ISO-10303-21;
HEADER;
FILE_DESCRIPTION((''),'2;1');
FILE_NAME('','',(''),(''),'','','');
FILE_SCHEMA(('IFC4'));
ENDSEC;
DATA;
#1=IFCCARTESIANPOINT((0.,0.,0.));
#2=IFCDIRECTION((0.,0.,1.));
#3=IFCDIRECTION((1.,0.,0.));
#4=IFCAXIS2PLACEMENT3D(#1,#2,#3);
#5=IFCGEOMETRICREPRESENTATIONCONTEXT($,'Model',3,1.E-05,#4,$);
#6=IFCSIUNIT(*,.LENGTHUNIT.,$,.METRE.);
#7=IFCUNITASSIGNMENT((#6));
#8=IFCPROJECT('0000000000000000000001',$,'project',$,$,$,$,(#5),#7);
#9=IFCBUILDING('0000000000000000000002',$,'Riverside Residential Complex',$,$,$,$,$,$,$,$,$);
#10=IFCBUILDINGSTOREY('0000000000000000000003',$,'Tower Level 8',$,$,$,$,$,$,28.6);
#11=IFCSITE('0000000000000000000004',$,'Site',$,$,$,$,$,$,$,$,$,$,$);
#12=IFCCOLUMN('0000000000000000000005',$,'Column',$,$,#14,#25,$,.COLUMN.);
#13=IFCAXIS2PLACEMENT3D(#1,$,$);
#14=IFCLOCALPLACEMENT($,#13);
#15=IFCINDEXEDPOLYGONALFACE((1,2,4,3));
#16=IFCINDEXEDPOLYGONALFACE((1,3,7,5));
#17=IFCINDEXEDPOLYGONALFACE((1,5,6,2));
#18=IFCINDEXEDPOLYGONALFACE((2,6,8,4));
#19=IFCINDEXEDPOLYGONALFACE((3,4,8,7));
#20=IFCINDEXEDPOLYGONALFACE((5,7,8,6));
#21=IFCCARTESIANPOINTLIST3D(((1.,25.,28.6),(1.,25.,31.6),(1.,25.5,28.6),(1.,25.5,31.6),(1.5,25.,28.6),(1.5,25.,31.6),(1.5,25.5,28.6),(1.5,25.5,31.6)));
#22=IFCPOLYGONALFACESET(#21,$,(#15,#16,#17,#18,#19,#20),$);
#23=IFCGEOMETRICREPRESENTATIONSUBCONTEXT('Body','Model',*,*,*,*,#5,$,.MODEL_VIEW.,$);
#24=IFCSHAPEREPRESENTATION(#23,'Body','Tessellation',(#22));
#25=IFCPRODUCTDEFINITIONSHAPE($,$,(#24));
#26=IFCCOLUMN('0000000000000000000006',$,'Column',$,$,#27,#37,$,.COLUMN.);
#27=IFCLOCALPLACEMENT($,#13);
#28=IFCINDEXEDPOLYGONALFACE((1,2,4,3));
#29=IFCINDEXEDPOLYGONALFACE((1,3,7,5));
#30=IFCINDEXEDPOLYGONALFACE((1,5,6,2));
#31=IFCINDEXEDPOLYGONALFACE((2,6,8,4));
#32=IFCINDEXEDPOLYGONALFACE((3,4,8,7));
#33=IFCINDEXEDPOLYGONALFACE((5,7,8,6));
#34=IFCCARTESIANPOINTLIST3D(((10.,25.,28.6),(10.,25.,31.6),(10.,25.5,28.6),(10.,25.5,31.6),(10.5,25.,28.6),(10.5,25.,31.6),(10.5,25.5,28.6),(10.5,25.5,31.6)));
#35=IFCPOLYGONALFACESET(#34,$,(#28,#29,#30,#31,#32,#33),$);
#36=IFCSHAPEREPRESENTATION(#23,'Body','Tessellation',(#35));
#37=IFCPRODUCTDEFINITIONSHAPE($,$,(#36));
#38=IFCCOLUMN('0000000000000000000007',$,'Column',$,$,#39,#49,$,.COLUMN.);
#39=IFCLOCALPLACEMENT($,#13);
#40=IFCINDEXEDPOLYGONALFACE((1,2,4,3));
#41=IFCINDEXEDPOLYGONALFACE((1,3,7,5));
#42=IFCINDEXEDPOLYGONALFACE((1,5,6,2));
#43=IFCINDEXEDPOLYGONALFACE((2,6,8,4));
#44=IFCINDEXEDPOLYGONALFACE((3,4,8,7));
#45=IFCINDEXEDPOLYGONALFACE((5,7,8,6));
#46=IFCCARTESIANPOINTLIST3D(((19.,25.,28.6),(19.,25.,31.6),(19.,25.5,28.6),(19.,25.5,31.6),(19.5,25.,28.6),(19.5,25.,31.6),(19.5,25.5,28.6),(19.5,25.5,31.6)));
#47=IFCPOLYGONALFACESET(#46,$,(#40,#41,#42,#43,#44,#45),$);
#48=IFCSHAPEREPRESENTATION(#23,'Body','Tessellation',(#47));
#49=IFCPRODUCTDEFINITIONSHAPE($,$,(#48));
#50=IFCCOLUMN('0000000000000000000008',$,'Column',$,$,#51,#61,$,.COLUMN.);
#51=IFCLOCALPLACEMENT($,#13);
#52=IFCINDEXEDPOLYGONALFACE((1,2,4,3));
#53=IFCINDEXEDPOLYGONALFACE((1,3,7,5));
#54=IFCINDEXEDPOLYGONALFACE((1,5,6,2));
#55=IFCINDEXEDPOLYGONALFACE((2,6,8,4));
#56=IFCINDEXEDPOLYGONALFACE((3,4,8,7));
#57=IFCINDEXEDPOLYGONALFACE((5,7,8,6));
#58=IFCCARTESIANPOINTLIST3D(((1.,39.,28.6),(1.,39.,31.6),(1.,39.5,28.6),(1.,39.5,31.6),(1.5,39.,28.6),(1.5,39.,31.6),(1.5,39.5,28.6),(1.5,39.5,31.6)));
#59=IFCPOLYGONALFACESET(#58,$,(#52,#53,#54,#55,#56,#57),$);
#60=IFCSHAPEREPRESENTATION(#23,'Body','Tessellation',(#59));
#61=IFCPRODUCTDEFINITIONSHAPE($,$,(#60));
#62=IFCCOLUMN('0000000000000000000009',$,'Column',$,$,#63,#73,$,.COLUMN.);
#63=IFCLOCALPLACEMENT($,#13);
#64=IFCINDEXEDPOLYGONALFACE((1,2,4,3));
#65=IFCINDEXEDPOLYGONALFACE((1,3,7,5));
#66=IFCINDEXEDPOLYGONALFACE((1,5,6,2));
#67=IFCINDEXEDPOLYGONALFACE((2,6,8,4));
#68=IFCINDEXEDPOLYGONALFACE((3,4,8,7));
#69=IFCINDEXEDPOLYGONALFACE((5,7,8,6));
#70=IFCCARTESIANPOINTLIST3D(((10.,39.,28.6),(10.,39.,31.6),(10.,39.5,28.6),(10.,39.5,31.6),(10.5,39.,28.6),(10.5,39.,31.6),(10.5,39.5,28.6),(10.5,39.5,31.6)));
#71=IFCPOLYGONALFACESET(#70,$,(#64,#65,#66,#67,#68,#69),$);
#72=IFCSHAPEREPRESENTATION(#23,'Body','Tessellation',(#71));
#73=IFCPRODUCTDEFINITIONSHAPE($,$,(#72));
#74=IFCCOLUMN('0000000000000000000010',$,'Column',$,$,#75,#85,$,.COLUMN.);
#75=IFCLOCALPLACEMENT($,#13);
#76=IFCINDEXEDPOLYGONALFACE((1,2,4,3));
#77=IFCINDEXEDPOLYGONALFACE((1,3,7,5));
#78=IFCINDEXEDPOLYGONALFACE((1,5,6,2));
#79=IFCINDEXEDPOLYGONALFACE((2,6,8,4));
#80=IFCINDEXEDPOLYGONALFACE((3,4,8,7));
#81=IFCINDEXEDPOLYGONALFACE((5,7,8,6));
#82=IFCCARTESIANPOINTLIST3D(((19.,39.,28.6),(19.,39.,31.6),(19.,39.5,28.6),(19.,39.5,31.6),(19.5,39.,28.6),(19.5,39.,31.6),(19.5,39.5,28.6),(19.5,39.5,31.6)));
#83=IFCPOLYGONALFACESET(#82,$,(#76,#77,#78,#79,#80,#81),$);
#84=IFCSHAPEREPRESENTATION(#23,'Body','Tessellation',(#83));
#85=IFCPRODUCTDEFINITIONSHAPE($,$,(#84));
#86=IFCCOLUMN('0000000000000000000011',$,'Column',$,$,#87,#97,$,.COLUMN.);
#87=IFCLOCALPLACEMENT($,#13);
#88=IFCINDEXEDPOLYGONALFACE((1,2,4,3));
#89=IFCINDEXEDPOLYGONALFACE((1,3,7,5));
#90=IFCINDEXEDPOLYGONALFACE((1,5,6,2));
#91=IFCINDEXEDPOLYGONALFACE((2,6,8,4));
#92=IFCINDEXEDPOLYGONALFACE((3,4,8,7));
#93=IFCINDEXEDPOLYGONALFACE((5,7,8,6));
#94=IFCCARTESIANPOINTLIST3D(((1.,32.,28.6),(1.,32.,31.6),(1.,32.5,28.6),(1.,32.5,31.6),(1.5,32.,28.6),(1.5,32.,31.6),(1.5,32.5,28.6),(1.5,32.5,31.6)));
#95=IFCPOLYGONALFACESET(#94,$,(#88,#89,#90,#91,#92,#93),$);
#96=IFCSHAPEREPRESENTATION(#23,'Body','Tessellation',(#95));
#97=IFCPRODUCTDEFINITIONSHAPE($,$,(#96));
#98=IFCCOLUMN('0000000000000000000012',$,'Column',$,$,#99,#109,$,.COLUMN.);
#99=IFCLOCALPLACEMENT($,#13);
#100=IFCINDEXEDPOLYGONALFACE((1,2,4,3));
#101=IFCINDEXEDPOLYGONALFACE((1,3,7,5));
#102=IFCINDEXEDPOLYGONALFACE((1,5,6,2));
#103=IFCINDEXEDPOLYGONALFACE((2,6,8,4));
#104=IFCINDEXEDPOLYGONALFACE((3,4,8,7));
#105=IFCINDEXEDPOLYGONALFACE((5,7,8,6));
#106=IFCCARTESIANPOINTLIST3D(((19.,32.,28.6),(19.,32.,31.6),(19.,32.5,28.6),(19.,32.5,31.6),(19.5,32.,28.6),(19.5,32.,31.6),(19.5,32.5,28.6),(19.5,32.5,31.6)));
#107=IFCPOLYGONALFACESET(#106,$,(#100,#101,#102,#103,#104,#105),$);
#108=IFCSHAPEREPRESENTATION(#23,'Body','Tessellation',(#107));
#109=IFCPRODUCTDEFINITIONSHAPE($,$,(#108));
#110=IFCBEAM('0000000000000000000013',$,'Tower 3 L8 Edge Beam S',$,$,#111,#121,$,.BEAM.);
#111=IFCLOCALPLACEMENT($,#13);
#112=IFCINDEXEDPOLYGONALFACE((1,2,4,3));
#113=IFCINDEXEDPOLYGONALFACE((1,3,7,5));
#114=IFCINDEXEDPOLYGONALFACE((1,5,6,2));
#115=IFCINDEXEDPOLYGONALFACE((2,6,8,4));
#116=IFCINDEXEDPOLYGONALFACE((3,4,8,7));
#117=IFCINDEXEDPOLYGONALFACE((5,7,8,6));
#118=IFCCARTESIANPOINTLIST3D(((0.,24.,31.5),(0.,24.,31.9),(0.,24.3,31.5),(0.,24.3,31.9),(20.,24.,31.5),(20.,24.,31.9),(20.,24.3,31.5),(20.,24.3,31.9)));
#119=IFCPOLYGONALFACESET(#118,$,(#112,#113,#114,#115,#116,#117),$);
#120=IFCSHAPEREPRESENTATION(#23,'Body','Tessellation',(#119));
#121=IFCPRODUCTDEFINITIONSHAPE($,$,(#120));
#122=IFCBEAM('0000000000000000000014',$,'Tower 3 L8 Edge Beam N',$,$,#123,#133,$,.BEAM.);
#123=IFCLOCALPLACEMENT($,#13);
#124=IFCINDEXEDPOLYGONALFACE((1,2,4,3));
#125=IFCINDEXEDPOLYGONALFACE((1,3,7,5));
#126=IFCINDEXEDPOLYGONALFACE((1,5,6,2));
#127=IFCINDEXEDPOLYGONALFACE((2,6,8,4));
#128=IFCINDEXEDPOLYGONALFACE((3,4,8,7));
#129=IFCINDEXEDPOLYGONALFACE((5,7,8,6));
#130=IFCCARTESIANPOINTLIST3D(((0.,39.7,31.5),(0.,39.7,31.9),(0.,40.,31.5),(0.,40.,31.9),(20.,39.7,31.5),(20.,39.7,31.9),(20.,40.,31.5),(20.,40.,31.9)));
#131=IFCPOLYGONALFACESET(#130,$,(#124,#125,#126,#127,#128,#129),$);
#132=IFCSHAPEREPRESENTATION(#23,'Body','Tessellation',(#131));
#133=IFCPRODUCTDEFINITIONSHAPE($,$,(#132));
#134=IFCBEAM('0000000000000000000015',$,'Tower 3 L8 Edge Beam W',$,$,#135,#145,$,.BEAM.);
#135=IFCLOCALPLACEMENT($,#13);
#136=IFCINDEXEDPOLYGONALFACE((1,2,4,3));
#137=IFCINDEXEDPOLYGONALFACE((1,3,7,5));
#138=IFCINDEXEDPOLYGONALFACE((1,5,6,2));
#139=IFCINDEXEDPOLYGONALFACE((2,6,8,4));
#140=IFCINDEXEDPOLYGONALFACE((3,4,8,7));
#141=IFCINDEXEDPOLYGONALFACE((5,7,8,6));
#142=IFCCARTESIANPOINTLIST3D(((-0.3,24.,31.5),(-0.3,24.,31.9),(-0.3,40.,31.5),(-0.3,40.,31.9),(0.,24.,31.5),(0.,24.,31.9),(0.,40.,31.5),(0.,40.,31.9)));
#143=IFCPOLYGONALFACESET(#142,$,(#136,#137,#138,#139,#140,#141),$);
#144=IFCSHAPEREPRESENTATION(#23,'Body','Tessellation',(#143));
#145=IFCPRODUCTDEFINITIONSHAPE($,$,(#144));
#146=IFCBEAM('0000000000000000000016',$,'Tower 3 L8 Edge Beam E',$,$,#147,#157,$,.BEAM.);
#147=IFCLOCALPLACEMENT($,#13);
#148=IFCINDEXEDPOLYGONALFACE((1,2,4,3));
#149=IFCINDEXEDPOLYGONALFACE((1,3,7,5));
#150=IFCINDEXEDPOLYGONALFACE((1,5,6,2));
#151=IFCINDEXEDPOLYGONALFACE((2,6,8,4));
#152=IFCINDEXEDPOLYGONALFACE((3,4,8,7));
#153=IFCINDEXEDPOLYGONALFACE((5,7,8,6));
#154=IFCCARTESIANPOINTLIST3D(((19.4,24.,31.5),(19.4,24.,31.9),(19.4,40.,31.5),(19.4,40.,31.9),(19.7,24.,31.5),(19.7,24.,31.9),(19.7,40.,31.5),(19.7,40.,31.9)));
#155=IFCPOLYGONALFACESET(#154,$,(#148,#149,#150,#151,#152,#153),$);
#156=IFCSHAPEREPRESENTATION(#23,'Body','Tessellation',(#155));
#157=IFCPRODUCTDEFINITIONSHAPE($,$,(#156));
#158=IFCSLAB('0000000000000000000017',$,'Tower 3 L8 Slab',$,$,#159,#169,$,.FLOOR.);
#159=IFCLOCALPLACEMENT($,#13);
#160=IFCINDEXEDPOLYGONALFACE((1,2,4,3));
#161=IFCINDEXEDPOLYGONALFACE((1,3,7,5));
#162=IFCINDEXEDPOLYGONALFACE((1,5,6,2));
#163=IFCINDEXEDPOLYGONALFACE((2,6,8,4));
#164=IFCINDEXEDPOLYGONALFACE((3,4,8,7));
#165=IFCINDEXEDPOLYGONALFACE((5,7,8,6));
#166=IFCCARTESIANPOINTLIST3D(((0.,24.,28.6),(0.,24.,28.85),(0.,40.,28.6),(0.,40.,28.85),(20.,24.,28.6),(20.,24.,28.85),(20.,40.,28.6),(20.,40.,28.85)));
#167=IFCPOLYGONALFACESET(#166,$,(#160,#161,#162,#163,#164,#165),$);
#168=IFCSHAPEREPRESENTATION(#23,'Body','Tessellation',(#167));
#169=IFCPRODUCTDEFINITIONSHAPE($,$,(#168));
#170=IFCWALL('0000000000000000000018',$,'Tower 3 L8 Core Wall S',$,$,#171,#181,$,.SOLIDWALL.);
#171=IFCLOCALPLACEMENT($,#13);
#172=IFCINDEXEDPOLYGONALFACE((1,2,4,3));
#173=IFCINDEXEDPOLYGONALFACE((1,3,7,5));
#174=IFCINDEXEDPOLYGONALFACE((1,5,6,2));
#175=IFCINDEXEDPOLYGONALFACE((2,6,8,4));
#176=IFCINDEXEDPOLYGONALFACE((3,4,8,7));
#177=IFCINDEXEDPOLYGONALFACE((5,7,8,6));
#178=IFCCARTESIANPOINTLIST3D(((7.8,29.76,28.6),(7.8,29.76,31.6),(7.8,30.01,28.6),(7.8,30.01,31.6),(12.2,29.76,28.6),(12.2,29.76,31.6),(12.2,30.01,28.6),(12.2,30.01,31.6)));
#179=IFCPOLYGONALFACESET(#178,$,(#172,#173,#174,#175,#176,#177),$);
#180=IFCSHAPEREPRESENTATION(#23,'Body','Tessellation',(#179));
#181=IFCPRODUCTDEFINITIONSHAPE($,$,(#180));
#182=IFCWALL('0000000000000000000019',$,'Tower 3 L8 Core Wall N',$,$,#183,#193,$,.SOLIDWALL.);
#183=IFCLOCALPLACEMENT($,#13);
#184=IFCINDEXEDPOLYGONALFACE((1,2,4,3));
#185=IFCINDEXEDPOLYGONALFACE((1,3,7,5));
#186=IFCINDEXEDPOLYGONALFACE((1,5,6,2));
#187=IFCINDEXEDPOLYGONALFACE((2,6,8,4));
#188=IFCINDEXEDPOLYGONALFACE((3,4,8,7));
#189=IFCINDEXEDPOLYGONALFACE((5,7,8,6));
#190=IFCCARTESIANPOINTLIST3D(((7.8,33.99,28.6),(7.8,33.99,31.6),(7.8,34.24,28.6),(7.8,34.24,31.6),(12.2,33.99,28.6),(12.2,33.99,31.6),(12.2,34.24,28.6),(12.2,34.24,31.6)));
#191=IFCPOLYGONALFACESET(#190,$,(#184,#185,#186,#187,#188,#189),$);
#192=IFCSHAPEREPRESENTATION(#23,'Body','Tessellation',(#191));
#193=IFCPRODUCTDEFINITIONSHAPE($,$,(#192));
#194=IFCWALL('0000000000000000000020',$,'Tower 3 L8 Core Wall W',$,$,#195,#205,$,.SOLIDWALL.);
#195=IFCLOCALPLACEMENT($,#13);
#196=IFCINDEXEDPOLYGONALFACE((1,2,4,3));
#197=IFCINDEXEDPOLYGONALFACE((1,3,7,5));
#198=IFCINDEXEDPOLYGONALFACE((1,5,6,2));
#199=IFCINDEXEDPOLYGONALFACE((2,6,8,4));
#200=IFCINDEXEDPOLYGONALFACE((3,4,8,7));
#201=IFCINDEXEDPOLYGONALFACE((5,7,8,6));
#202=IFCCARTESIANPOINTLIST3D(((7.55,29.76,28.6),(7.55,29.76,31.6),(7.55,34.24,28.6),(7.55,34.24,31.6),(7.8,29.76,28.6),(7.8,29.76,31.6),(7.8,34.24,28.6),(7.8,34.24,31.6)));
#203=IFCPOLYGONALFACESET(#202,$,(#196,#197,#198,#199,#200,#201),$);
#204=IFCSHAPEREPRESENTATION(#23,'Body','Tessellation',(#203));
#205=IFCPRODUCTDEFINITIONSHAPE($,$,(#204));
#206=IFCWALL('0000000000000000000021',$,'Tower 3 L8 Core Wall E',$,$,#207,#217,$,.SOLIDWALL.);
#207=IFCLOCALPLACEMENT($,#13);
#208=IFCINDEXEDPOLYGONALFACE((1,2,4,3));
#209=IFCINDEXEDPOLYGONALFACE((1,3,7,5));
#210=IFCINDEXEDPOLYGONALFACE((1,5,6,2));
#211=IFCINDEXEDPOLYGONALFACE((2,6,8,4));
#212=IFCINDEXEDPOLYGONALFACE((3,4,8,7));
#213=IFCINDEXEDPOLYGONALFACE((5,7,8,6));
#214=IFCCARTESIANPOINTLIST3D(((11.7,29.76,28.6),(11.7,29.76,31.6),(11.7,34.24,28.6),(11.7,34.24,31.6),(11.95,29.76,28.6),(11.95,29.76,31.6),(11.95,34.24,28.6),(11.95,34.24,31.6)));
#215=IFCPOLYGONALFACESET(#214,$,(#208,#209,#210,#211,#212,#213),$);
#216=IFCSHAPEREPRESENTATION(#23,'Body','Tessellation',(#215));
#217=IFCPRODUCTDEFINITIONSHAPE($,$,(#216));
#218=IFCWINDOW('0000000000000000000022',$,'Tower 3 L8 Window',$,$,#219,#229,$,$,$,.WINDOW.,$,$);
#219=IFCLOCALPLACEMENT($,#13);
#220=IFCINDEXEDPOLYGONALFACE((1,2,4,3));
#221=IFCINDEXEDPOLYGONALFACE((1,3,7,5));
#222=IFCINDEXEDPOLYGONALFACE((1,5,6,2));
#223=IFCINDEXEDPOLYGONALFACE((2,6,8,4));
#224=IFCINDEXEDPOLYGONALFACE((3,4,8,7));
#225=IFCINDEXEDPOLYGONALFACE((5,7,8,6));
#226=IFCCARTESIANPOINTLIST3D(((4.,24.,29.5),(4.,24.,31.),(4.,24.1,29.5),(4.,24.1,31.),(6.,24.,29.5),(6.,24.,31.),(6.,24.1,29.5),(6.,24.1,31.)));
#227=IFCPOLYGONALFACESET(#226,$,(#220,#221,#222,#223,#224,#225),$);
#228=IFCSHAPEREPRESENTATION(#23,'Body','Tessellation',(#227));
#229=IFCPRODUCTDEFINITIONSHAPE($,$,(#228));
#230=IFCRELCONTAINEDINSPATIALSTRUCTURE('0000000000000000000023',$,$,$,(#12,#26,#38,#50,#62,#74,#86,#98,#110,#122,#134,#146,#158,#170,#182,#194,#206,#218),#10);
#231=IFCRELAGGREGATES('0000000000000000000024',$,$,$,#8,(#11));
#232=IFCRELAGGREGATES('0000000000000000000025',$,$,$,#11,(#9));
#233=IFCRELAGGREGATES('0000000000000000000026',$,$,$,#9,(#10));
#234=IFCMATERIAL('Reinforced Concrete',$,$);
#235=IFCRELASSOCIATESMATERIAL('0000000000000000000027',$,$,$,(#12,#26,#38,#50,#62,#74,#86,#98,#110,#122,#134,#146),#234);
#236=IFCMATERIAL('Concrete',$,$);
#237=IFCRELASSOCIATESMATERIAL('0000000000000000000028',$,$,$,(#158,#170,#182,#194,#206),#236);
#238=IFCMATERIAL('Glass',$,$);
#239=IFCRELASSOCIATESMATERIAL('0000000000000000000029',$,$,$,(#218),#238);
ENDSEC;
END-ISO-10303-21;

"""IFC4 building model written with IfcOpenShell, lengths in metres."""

from ifc_helpers import new_model, si_unit, frame, origin_with_axes, place, context, subcontext, project, spatial, line, indexed_curve, outline, extrude, material, element, save


model = new_model("IFC4")

# Units and contexts
model_context = context("Model", 3, precision=1e-05, world=origin_with_axes())
body_context = subcontext(model_context, "Body", "Model", "MODEL_VIEW")
ifc_project = project(units=[si_unit("LENGTHUNIT", "METRE")], contexts=[model_context])

# Site, building, storey
site = spatial("IfcSite", under=ifc_project, Name="Site")
building = spatial("IfcBuilding", under=site, Name="Riverside Residential Complex")
storey = spatial("IfcBuildingStorey", under=building, Name="Tower Level 8", Elevation=28.6)

# Columns
ifc_material_1 = material(Name="Reinforced Concrete")
for number, where, z_axis, x_axis, name in (
    (1, (1.0, 25.0, 28.6), (0.0, 0.0, 1.0), (1.0, 0.0, 0.0), "Column"),
    (2, (10.0, 25.0, 28.6), (0.0, 0.0, 1.0), (1.0, 0.0, 0.0), "Column"),
    (3, (19.0, 25.0, 28.6), (0.0, 0.0, 1.0), (1.0, 0.0, 0.0), "Column"),
    (4, (1.0, 39.0, 28.6), (0.0, 0.0, 1.0), (1.0, 0.0, 0.0), "Column"),
    (5, (10.0, 39.0, 28.6), (0.0, 0.0, 1.0), (1.0, 0.0, 0.0), "Column"),
    (6, (19.0, 39.0, 28.6), (0.0, 0.0, 1.0), (1.0, 0.0, 0.0), "Column"),
    (7, (1.0, 32.0, 28.6), (0.0, 0.0, 1.0), (1.0, 0.0, 0.0), "Column"),
    (8, (19.0, 32.0, 28.6), (0.0, 0.0, 1.0), (1.0, 0.0, 0.0), "Column"),
):
    element("IfcColumn", number, at=place(None, frame(where, z_axis=z_axis, x_axis=x_axis)), inside=storey, material=ifc_material_1, Name=name, PredefinedType="COLUMN", context=body_context, shape_type="SweptSolid", body=[
        extrude(outline(indexed_curve([(0.0, 0.0), (0.5, 0.0), (0.5, 0.5), (0.0, 0.5)], segments=[line(1, 2, 3, 4, 1)])), origin_with_axes(), (0.0, 0.0, 1.0), 3.0),
    ])

# Beams
for number, where, z_axis, x_axis, name in (
    (9, (0.0, 24.0, 31.5), (0.0, 0.0, 1.0), (1.0, 0.0, 0.0), "Tower 3 L8 Edge Beam S"),
    (10, (0.0, 39.7, 31.5), (0.0, 0.0, 1.0), (1.0, 0.0, 0.0), "Tower 3 L8 Edge Beam N"),
):
    element("IfcBeam", number, at=place(None, frame(where, z_axis=z_axis, x_axis=x_axis)), inside=storey, material=ifc_material_1, Name=name, PredefinedType="BEAM", context=body_context, shape_type="SweptSolid", body=[
        extrude(outline(indexed_curve([(0.0, 0.0), (20.0, 0.0), (20.0, 0.3), (0.0, 0.3)], segments=[line(1, 2, 3, 4, 1)])), origin_with_axes(), (0.0, 0.0, 1.0), 0.4),
    ])
for number, where, z_axis, x_axis, name in (
    (11, (0.0, 24.0, 31.5), (0.0, 0.0, 1.0), (0.0, 1.0, 0.0), "Tower 3 L8 Edge Beam W"),
    (12, (19.7, 24.0, 31.5), (0.0, 0.0, 1.0), (0.0, 1.0, 0.0), "Tower 3 L8 Edge Beam E"),
):
    element("IfcBeam", number, at=place(None, frame(where, z_axis=z_axis, x_axis=x_axis)), inside=storey, material=ifc_material_1, Name=name, PredefinedType="BEAM", context=body_context, shape_type="SweptSolid", body=[
        extrude(outline(indexed_curve([(0.0, 0.0), (16.0, 0.0), (16.0, 0.3), (0.0, 0.3)], segments=[line(1, 2, 3, 4, 1)])), origin_with_axes(), (0.0, 0.0, 1.0), 0.4),
    ])

# Slab
ifc_material_2 = material(Name="Concrete")
slab_placement = place(None, frame((0.0, 24.0, 28.6), z_axis=(0.0, 0.0, 1.0), x_axis=(1.0, 0.0, 0.0)))
element("IfcSlab", 13, at=slab_placement, inside=storey, material=ifc_material_2, Name="Tower 3 L8 Slab", PredefinedType="FLOOR", context=body_context, shape_type="SweptSolid", body=[
    extrude(outline(indexed_curve([(0.0, 0.0), (20.0, 0.0), (20.0, 16.0), (0.0, 16.0)], segments=[line(1, 2, 3, 4, 1)])), origin_with_axes(), (0.0, 0.0, 1.0), 0.25),
])

# Walls
for number, where, z_axis, x_axis, name in (
    (14, (7.8, 29.76, 28.6), (0.0, 0.0, 1.0), (1.0, 0.0, 0.0), "Tower 3 L8 Core Wall S"),
    (15, (7.8, 33.99, 28.6), (0.0, 0.0, 1.0), (1.0, 0.0, 0.0), "Tower 3 L8 Core Wall N"),
):
    element("IfcWall", number, at=place(None, frame(where, z_axis=z_axis, x_axis=x_axis)), inside=storey, material=ifc_material_2, Name=name, PredefinedType="SOLIDWALL", context=body_context, shape_type="SweptSolid", body=[
        extrude(outline(indexed_curve([(0.0, 0.0), (4.4, 0.0), (4.4, 0.25), (0.0, 0.25)], segments=[line(1, 2, 3, 4, 1)])), origin_with_axes(), (0.0, 0.0, 1.0), 3.0),
    ])
for number, where, z_axis, x_axis, name in (
    (16, (7.8, 29.76, 28.6), (0.0, 0.0, 1.0), (0.0, 1.0, 0.0), "Tower 3 L8 Core Wall W"),
    (17, (11.95, 29.76, 28.6), (0.0, 0.0, 1.0), (0.0, 1.0, 0.0), "Tower 3 L8 Core Wall E"),
):
    element("IfcWall", number, at=place(None, frame(where, z_axis=z_axis, x_axis=x_axis)), inside=storey, material=ifc_material_2, Name=name, PredefinedType="SOLIDWALL", context=body_context, shape_type="SweptSolid", body=[
        extrude(outline(indexed_curve([(0.0, 0.0), (4.48, 0.0), (4.48, 0.25), (0.0, 0.25)], segments=[line(1, 2, 3, 4, 1)])), origin_with_axes(), (0.0, 0.0, 1.0), 3.0),
    ])

# Window
ifc_material_3 = material(Name="Glass")
for number, where, z_axis, x_axis, name in (
    (18, (4.0, 24.0, 29.5), (0.0, 0.0, 1.0), (1.0, 0.0, 0.0), "Tower 3 L8 Window"),
):
    element("IfcWindow", number, at=place(None, frame(where, z_axis=z_axis, x_axis=x_axis)), inside=storey, material=ifc_material_3, Name=name, PredefinedType="WINDOW", context=body_context, shape_type="SweptSolid", body=[
        extrude(outline(indexed_curve([(0.0, 0.0), (2.0, 0.0), (2.0, 0.1), (0.0, 0.1)], segments=[line(1, 2, 3, 4, 1)])), origin_with_axes(), (0.0, 0.0, 1.0), 1.5),
    ])

save(model, "model.ifc")
